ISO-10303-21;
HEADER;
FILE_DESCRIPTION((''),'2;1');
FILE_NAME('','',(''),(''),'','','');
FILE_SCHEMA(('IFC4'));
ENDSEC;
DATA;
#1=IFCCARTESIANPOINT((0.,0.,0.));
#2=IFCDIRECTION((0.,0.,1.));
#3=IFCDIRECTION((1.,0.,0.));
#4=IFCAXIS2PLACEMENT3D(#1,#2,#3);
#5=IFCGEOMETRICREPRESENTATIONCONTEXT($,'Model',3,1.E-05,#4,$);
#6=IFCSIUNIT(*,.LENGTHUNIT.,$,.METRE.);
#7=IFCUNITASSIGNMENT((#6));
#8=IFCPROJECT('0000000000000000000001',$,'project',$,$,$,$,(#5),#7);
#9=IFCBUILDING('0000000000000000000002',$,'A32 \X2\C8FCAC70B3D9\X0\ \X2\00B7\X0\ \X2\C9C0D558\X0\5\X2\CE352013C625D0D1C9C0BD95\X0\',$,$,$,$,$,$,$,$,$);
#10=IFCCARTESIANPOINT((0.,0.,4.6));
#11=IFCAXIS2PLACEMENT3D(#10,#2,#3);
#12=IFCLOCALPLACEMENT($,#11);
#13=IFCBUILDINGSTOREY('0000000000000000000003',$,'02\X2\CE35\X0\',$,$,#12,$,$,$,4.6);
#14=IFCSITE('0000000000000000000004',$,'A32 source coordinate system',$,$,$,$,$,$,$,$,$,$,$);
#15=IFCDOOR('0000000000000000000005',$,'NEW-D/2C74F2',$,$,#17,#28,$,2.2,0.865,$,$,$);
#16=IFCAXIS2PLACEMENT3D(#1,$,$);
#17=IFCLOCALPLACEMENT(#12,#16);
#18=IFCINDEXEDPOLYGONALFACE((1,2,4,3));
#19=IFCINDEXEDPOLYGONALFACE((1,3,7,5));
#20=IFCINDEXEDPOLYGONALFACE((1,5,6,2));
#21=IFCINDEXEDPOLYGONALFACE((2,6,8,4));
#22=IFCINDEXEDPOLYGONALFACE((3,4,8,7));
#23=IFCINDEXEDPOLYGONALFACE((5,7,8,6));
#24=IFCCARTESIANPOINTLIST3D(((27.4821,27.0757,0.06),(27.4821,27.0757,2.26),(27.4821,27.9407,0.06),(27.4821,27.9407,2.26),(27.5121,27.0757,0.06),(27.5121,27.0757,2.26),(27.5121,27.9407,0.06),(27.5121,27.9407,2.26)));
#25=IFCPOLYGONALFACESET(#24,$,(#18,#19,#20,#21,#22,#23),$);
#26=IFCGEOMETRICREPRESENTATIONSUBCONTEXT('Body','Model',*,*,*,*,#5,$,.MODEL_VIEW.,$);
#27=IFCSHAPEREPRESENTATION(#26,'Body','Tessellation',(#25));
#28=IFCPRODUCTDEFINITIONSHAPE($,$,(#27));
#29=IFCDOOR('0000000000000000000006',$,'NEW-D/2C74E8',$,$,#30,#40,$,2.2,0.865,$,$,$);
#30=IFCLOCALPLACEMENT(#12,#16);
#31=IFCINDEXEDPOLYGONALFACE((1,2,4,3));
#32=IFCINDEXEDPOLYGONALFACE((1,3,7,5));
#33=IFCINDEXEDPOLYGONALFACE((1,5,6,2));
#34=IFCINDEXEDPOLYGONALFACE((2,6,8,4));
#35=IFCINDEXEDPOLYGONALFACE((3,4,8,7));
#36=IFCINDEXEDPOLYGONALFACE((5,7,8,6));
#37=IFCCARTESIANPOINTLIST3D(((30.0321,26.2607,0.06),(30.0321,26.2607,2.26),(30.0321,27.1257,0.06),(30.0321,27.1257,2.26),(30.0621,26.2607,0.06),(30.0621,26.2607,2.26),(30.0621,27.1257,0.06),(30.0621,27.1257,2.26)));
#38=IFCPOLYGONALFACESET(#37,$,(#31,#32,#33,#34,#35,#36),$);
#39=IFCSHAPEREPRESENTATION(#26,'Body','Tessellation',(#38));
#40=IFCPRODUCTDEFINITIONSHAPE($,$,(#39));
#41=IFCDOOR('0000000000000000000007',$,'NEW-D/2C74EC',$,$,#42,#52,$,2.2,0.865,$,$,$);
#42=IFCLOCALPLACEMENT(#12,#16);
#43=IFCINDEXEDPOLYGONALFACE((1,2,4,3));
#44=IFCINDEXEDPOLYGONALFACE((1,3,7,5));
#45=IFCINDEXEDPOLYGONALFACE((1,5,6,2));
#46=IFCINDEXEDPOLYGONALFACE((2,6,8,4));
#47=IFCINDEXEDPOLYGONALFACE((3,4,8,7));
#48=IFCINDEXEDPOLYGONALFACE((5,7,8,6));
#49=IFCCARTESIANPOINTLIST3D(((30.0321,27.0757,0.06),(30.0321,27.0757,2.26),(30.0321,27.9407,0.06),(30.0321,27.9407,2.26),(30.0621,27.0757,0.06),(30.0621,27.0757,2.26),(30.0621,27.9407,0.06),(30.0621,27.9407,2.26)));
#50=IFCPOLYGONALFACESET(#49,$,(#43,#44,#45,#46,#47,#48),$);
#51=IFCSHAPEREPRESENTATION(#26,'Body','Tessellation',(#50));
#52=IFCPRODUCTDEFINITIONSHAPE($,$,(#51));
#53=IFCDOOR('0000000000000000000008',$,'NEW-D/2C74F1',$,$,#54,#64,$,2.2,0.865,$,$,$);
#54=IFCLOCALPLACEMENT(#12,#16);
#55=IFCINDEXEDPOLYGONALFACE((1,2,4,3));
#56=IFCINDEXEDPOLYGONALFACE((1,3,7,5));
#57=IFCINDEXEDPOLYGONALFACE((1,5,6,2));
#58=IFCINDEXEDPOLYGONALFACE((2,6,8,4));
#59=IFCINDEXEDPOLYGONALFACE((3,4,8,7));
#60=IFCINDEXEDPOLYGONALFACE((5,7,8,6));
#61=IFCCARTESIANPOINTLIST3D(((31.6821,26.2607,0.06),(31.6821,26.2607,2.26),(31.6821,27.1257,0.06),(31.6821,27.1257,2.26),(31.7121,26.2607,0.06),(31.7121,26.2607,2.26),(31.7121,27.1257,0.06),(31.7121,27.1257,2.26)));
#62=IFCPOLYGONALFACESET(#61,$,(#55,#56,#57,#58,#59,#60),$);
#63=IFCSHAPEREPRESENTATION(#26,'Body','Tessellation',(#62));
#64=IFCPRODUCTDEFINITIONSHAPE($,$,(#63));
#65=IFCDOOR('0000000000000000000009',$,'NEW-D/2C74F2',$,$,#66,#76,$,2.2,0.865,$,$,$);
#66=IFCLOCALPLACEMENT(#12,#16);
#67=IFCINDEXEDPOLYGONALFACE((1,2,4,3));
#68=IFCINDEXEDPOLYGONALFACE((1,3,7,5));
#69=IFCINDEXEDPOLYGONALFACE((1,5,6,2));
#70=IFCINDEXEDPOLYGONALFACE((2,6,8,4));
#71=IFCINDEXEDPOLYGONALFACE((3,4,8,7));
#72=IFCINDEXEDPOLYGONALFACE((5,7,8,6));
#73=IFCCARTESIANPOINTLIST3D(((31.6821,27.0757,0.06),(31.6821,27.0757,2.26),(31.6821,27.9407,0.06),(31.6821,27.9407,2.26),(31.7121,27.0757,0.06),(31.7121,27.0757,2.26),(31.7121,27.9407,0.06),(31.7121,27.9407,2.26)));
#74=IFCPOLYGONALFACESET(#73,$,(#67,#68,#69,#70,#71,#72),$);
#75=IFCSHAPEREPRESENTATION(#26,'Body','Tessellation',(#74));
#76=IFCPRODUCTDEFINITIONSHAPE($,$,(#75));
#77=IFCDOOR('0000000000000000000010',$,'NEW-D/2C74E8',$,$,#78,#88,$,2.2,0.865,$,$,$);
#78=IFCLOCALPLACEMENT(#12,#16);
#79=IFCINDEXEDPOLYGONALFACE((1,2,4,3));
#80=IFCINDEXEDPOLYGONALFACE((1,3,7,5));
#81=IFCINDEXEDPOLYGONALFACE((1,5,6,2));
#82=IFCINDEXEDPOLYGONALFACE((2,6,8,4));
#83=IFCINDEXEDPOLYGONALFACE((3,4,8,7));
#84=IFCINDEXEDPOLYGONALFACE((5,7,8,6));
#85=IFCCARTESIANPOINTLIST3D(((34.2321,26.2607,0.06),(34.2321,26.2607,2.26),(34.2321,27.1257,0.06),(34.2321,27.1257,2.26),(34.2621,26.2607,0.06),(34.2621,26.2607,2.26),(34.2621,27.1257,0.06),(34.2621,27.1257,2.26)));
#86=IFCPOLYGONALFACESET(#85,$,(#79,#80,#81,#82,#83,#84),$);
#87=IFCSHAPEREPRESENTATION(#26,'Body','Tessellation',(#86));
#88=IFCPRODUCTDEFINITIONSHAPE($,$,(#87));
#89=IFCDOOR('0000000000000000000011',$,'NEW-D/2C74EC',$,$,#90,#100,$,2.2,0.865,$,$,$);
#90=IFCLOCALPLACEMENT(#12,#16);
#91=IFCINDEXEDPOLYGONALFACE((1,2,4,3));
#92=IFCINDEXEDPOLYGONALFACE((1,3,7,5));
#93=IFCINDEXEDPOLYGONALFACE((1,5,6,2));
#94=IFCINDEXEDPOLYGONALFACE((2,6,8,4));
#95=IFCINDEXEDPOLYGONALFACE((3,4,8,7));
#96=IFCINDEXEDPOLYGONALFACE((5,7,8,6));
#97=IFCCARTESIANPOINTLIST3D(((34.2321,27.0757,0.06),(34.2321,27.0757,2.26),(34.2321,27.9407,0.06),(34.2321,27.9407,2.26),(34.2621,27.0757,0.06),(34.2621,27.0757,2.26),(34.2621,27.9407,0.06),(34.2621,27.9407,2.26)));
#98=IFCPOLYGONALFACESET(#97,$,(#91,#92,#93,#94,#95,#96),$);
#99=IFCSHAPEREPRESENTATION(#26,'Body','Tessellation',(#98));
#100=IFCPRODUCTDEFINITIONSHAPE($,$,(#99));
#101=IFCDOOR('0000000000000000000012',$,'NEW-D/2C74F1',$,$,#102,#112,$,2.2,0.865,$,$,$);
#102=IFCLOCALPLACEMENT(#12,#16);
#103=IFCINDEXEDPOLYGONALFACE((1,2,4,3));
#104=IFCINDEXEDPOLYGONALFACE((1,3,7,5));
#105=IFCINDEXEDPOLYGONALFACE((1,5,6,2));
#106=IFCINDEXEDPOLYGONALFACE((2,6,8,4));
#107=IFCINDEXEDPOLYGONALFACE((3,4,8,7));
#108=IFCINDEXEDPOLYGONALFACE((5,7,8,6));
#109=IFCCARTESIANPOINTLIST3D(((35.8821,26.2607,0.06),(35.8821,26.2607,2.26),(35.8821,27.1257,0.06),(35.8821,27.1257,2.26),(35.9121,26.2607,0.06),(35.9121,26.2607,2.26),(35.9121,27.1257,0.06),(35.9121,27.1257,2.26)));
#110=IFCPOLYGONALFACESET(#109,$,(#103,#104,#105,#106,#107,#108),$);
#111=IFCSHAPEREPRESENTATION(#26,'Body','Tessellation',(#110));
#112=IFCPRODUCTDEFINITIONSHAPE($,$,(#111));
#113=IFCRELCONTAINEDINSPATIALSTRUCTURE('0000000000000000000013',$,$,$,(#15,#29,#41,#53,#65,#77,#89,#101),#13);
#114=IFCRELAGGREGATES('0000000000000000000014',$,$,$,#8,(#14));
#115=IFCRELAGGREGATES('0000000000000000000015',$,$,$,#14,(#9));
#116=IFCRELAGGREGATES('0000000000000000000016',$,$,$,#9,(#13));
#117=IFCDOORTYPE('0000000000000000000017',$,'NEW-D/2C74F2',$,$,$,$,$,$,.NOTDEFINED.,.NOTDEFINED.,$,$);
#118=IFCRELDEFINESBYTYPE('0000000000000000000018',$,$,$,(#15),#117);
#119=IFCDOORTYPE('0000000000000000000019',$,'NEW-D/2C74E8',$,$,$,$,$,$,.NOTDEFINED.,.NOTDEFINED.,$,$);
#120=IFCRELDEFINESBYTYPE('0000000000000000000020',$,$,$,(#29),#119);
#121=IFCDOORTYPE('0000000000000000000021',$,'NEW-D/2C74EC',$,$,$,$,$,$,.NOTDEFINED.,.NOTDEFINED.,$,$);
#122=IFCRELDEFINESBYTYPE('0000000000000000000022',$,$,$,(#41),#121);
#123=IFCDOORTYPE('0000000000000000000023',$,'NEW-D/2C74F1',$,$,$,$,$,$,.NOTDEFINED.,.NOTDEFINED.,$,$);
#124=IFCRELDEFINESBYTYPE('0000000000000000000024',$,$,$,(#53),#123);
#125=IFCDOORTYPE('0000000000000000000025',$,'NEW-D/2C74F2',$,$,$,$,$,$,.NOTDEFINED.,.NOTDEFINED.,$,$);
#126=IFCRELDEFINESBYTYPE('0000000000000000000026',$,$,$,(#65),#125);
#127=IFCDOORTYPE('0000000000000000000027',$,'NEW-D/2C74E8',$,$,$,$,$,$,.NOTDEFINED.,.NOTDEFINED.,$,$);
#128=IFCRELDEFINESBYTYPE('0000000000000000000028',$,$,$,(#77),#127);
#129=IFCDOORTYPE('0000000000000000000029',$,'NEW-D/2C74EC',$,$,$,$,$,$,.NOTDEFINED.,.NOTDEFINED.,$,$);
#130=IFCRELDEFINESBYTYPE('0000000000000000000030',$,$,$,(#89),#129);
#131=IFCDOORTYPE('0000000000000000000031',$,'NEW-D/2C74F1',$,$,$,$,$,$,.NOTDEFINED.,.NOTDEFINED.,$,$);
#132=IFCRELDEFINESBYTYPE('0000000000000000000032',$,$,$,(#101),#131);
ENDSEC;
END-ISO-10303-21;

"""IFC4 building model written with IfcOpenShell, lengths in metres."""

from ifc_helpers import new_model, si_unit, frame, origin, origin_with_axes, place, context, subcontext, project, spatial, polyline, outline, extrude, source, transform, mapped, type_object, type_shapes, element, save


model = new_model("IFC4")

# Units and contexts
model_context = context("Model", 3, precision=1e-05, world=origin_with_axes())
body_context = subcontext(model_context, "Body", "Model", "MODEL_VIEW")
ifc_project = project(units=[si_unit("LENGTHUNIT", "METRE")], contexts=[model_context])

# Site, building, storey
site = spatial("IfcSite", under=ifc_project, Name="A32 source coordinate system")
building = spatial("IfcBuilding", under=site, Name="A32 주거동 · 지하5층–옥탑지붕")
storey_placement = place(None, frame((0.0, 0.0, 4.6), z_axis=(0.0, 0.0, 1.0), x_axis=(1.0, 0.0, 0.0)))
storey = spatial("IfcBuildingStorey", under=building, at=storey_placement, Name="02층", Elevation=4.6)

# Doors
door_type_1 = type_object("IfcDoorType", Name="NEW-D/2C74F2", OperationType="NOTDEFINED", PredefinedType="NOTDEFINED")
shared_shape_1 = source(origin(), body_context, "Body", "SweptSolid", [
    extrude(outline(polyline([(27.4821, 27.0757), (27.4821, 27.9407), (27.5121, 27.9407), (27.5121, 27.0757), (27.4821, 27.0757)])), frame((0.0, 0.0, 0.06)), (0.0, 0.0, 1.0), 2.2),
])
type_shapes(door_type_1, [shared_shape_1])
door_1_placement = place(storey_placement, origin_with_axes())
element("IfcDoor", 1, at=door_1_placement, inside=storey, type_object=door_type_1, Name="NEW-D/2C74F2", OverallHeight=2.2, OverallWidth=0.865, context=body_context, shape_type="MappedRepresentation", body=[
    mapped(shared_shape_1, transform((0.0, 0.0, 0.0), scale=1.0)),
])
door_type_2 = type_object("IfcDoorType", Name="NEW-D/2C74E8", OperationType="NOTDEFINED", PredefinedType="NOTDEFINED")
shared_shape_2 = source(origin(), body_context, "Body", "SweptSolid", [
    extrude(outline(polyline([(30.0621, 27.1257), (30.0621, 26.2607), (30.0321, 26.2607), (30.0321, 27.1257), (30.0621, 27.1257)])), frame((0.0, 0.0, 0.06)), (0.0, 0.0, 1.0), 2.2),
])
type_shapes(door_type_2, [shared_shape_2])
door_2_placement = place(storey_placement, origin_with_axes())
element("IfcDoor", 2, at=door_2_placement, inside=storey, type_object=door_type_2, Name="NEW-D/2C74E8", OverallHeight=2.2, OverallWidth=0.865, context=body_context, shape_type="MappedRepresentation", body=[
    mapped(shared_shape_2, transform((0.0, 0.0, 0.0), scale=1.0)),
])
door_type_3 = type_object("IfcDoorType", Name="NEW-D/2C74EC", OperationType="NOTDEFINED", PredefinedType="NOTDEFINED")
shared_shape_3 = source(origin(), body_context, "Body", "SweptSolid", [
    extrude(outline(polyline([(30.0321, 27.9407), (30.0621, 27.9407), (30.0621, 27.0757), (30.0321, 27.0757), (30.0321, 27.9407)])), frame((0.0, 0.0, 0.06)), (0.0, 0.0, 1.0), 2.2),
])
type_shapes(door_type_3, [shared_shape_3])
door_3_placement = place(storey_placement, origin_with_axes())
element("IfcDoor", 3, at=door_3_placement, inside=storey, type_object=door_type_3, Name="NEW-D/2C74EC", OverallHeight=2.2, OverallWidth=0.865, context=body_context, shape_type="MappedRepresentation", body=[
    mapped(shared_shape_3, transform((0.0, 0.0, 0.0), scale=1.0)),
])
door_type_4 = type_object("IfcDoorType", Name="NEW-D/2C74F1", OperationType="NOTDEFINED", PredefinedType="NOTDEFINED")
shared_shape_4 = source(origin(), body_context, "Body", "SweptSolid", [
    extrude(outline(polyline([(31.7121, 26.2607), (31.6821, 26.2607), (31.6821, 27.1257), (31.7121, 27.1257), (31.7121, 26.2607)])), frame((0.0, 0.0, 0.06)), (0.0, 0.0, 1.0), 2.2),
])
type_shapes(door_type_4, [shared_shape_4])
door_4_placement = place(storey_placement, origin_with_axes())
element("IfcDoor", 4, at=door_4_placement, inside=storey, type_object=door_type_4, Name="NEW-D/2C74F1", OverallHeight=2.2, OverallWidth=0.865, context=body_context, shape_type="MappedRepresentation", body=[
    mapped(shared_shape_4, transform((0.0, 0.0, 0.0), scale=1.0)),
])
door_type_5 = type_object("IfcDoorType", Name="NEW-D/2C74F2", OperationType="NOTDEFINED", PredefinedType="NOTDEFINED")
shared_shape_5 = source(origin(), body_context, "Body", "SweptSolid", [
    extrude(outline(polyline([(31.6821, 27.0757), (31.6821, 27.9407), (31.7121, 27.9407), (31.7121, 27.0757), (31.6821, 27.0757)])), frame((0.0, 0.0, 0.06)), (0.0, 0.0, 1.0), 2.2),
])
type_shapes(door_type_5, [shared_shape_5])
door_5_placement = place(storey_placement, origin_with_axes())
element("IfcDoor", 5, at=door_5_placement, inside=storey, type_object=door_type_5, Name="NEW-D/2C74F2", OverallHeight=2.2, OverallWidth=0.865, context=body_context, shape_type="MappedRepresentation", body=[
    mapped(shared_shape_5, transform((0.0, 0.0, 0.0), scale=1.0)),
])
door_type_6 = type_object("IfcDoorType", Name="NEW-D/2C74E8", OperationType="NOTDEFINED", PredefinedType="NOTDEFINED")
shared_shape_6 = source(origin(), body_context, "Body", "SweptSolid", [
    extrude(outline(polyline([(34.2621, 27.1257), (34.2621, 26.2607), (34.2321, 26.2607), (34.2321, 27.1257), (34.2621, 27.1257)])), frame((0.0, 0.0, 0.06)), (0.0, 0.0, 1.0), 2.2),
])
type_shapes(door_type_6, [shared_shape_6])
door_6_placement = place(storey_placement, origin_with_axes())
element("IfcDoor", 6, at=door_6_placement, inside=storey, type_object=door_type_6, Name="NEW-D/2C74E8", OverallHeight=2.2, OverallWidth=0.865, context=body_context, shape_type="MappedRepresentation", body=[
    mapped(shared_shape_6, transform((0.0, 0.0, 0.0), scale=1.0)),
])
door_type_7 = type_object("IfcDoorType", Name="NEW-D/2C74EC", OperationType="NOTDEFINED", PredefinedType="NOTDEFINED")
shared_shape_7 = source(origin(), body_context, "Body", "SweptSolid", [
    extrude(outline(polyline([(34.2321, 27.9407), (34.2621, 27.9407), (34.2621, 27.0757), (34.2321, 27.0757), (34.2321, 27.9407)])), frame((0.0, 0.0, 0.06)), (0.0, 0.0, 1.0), 2.2),
])
type_shapes(door_type_7, [shared_shape_7])
door_7_placement = place(storey_placement, origin_with_axes())
element("IfcDoor", 7, at=door_7_placement, inside=storey, type_object=door_type_7, Name="NEW-D/2C74EC", OverallHeight=2.2, OverallWidth=0.865, context=body_context, shape_type="MappedRepresentation", body=[
    mapped(shared_shape_7, transform((0.0, 0.0, 0.0), scale=1.0)),
])
door_type_8 = type_object("IfcDoorType", Name="NEW-D/2C74F1", OperationType="NOTDEFINED", PredefinedType="NOTDEFINED")
shared_shape_8 = source(origin(), body_context, "Body", "SweptSolid", [
    extrude(outline(polyline([(35.9121, 26.2607), (35.8821, 26.2607), (35.8821, 27.1257), (35.9121, 27.1257), (35.9121, 26.2607)])), frame((0.0, 0.0, 0.06)), (0.0, 0.0, 1.0), 2.2),
])
type_shapes(door_type_8, [shared_shape_8])
door_8_placement = place(storey_placement, origin_with_axes())
element("IfcDoor", 8, at=door_8_placement, inside=storey, type_object=door_type_8, Name="NEW-D/2C74F1", OverallHeight=2.2, OverallWidth=0.865, context=body_context, shape_type="MappedRepresentation", body=[
    mapped(shared_shape_8, transform((0.0, 0.0, 0.0), scale=1.0)),
])

save(model, "model.ifc")
